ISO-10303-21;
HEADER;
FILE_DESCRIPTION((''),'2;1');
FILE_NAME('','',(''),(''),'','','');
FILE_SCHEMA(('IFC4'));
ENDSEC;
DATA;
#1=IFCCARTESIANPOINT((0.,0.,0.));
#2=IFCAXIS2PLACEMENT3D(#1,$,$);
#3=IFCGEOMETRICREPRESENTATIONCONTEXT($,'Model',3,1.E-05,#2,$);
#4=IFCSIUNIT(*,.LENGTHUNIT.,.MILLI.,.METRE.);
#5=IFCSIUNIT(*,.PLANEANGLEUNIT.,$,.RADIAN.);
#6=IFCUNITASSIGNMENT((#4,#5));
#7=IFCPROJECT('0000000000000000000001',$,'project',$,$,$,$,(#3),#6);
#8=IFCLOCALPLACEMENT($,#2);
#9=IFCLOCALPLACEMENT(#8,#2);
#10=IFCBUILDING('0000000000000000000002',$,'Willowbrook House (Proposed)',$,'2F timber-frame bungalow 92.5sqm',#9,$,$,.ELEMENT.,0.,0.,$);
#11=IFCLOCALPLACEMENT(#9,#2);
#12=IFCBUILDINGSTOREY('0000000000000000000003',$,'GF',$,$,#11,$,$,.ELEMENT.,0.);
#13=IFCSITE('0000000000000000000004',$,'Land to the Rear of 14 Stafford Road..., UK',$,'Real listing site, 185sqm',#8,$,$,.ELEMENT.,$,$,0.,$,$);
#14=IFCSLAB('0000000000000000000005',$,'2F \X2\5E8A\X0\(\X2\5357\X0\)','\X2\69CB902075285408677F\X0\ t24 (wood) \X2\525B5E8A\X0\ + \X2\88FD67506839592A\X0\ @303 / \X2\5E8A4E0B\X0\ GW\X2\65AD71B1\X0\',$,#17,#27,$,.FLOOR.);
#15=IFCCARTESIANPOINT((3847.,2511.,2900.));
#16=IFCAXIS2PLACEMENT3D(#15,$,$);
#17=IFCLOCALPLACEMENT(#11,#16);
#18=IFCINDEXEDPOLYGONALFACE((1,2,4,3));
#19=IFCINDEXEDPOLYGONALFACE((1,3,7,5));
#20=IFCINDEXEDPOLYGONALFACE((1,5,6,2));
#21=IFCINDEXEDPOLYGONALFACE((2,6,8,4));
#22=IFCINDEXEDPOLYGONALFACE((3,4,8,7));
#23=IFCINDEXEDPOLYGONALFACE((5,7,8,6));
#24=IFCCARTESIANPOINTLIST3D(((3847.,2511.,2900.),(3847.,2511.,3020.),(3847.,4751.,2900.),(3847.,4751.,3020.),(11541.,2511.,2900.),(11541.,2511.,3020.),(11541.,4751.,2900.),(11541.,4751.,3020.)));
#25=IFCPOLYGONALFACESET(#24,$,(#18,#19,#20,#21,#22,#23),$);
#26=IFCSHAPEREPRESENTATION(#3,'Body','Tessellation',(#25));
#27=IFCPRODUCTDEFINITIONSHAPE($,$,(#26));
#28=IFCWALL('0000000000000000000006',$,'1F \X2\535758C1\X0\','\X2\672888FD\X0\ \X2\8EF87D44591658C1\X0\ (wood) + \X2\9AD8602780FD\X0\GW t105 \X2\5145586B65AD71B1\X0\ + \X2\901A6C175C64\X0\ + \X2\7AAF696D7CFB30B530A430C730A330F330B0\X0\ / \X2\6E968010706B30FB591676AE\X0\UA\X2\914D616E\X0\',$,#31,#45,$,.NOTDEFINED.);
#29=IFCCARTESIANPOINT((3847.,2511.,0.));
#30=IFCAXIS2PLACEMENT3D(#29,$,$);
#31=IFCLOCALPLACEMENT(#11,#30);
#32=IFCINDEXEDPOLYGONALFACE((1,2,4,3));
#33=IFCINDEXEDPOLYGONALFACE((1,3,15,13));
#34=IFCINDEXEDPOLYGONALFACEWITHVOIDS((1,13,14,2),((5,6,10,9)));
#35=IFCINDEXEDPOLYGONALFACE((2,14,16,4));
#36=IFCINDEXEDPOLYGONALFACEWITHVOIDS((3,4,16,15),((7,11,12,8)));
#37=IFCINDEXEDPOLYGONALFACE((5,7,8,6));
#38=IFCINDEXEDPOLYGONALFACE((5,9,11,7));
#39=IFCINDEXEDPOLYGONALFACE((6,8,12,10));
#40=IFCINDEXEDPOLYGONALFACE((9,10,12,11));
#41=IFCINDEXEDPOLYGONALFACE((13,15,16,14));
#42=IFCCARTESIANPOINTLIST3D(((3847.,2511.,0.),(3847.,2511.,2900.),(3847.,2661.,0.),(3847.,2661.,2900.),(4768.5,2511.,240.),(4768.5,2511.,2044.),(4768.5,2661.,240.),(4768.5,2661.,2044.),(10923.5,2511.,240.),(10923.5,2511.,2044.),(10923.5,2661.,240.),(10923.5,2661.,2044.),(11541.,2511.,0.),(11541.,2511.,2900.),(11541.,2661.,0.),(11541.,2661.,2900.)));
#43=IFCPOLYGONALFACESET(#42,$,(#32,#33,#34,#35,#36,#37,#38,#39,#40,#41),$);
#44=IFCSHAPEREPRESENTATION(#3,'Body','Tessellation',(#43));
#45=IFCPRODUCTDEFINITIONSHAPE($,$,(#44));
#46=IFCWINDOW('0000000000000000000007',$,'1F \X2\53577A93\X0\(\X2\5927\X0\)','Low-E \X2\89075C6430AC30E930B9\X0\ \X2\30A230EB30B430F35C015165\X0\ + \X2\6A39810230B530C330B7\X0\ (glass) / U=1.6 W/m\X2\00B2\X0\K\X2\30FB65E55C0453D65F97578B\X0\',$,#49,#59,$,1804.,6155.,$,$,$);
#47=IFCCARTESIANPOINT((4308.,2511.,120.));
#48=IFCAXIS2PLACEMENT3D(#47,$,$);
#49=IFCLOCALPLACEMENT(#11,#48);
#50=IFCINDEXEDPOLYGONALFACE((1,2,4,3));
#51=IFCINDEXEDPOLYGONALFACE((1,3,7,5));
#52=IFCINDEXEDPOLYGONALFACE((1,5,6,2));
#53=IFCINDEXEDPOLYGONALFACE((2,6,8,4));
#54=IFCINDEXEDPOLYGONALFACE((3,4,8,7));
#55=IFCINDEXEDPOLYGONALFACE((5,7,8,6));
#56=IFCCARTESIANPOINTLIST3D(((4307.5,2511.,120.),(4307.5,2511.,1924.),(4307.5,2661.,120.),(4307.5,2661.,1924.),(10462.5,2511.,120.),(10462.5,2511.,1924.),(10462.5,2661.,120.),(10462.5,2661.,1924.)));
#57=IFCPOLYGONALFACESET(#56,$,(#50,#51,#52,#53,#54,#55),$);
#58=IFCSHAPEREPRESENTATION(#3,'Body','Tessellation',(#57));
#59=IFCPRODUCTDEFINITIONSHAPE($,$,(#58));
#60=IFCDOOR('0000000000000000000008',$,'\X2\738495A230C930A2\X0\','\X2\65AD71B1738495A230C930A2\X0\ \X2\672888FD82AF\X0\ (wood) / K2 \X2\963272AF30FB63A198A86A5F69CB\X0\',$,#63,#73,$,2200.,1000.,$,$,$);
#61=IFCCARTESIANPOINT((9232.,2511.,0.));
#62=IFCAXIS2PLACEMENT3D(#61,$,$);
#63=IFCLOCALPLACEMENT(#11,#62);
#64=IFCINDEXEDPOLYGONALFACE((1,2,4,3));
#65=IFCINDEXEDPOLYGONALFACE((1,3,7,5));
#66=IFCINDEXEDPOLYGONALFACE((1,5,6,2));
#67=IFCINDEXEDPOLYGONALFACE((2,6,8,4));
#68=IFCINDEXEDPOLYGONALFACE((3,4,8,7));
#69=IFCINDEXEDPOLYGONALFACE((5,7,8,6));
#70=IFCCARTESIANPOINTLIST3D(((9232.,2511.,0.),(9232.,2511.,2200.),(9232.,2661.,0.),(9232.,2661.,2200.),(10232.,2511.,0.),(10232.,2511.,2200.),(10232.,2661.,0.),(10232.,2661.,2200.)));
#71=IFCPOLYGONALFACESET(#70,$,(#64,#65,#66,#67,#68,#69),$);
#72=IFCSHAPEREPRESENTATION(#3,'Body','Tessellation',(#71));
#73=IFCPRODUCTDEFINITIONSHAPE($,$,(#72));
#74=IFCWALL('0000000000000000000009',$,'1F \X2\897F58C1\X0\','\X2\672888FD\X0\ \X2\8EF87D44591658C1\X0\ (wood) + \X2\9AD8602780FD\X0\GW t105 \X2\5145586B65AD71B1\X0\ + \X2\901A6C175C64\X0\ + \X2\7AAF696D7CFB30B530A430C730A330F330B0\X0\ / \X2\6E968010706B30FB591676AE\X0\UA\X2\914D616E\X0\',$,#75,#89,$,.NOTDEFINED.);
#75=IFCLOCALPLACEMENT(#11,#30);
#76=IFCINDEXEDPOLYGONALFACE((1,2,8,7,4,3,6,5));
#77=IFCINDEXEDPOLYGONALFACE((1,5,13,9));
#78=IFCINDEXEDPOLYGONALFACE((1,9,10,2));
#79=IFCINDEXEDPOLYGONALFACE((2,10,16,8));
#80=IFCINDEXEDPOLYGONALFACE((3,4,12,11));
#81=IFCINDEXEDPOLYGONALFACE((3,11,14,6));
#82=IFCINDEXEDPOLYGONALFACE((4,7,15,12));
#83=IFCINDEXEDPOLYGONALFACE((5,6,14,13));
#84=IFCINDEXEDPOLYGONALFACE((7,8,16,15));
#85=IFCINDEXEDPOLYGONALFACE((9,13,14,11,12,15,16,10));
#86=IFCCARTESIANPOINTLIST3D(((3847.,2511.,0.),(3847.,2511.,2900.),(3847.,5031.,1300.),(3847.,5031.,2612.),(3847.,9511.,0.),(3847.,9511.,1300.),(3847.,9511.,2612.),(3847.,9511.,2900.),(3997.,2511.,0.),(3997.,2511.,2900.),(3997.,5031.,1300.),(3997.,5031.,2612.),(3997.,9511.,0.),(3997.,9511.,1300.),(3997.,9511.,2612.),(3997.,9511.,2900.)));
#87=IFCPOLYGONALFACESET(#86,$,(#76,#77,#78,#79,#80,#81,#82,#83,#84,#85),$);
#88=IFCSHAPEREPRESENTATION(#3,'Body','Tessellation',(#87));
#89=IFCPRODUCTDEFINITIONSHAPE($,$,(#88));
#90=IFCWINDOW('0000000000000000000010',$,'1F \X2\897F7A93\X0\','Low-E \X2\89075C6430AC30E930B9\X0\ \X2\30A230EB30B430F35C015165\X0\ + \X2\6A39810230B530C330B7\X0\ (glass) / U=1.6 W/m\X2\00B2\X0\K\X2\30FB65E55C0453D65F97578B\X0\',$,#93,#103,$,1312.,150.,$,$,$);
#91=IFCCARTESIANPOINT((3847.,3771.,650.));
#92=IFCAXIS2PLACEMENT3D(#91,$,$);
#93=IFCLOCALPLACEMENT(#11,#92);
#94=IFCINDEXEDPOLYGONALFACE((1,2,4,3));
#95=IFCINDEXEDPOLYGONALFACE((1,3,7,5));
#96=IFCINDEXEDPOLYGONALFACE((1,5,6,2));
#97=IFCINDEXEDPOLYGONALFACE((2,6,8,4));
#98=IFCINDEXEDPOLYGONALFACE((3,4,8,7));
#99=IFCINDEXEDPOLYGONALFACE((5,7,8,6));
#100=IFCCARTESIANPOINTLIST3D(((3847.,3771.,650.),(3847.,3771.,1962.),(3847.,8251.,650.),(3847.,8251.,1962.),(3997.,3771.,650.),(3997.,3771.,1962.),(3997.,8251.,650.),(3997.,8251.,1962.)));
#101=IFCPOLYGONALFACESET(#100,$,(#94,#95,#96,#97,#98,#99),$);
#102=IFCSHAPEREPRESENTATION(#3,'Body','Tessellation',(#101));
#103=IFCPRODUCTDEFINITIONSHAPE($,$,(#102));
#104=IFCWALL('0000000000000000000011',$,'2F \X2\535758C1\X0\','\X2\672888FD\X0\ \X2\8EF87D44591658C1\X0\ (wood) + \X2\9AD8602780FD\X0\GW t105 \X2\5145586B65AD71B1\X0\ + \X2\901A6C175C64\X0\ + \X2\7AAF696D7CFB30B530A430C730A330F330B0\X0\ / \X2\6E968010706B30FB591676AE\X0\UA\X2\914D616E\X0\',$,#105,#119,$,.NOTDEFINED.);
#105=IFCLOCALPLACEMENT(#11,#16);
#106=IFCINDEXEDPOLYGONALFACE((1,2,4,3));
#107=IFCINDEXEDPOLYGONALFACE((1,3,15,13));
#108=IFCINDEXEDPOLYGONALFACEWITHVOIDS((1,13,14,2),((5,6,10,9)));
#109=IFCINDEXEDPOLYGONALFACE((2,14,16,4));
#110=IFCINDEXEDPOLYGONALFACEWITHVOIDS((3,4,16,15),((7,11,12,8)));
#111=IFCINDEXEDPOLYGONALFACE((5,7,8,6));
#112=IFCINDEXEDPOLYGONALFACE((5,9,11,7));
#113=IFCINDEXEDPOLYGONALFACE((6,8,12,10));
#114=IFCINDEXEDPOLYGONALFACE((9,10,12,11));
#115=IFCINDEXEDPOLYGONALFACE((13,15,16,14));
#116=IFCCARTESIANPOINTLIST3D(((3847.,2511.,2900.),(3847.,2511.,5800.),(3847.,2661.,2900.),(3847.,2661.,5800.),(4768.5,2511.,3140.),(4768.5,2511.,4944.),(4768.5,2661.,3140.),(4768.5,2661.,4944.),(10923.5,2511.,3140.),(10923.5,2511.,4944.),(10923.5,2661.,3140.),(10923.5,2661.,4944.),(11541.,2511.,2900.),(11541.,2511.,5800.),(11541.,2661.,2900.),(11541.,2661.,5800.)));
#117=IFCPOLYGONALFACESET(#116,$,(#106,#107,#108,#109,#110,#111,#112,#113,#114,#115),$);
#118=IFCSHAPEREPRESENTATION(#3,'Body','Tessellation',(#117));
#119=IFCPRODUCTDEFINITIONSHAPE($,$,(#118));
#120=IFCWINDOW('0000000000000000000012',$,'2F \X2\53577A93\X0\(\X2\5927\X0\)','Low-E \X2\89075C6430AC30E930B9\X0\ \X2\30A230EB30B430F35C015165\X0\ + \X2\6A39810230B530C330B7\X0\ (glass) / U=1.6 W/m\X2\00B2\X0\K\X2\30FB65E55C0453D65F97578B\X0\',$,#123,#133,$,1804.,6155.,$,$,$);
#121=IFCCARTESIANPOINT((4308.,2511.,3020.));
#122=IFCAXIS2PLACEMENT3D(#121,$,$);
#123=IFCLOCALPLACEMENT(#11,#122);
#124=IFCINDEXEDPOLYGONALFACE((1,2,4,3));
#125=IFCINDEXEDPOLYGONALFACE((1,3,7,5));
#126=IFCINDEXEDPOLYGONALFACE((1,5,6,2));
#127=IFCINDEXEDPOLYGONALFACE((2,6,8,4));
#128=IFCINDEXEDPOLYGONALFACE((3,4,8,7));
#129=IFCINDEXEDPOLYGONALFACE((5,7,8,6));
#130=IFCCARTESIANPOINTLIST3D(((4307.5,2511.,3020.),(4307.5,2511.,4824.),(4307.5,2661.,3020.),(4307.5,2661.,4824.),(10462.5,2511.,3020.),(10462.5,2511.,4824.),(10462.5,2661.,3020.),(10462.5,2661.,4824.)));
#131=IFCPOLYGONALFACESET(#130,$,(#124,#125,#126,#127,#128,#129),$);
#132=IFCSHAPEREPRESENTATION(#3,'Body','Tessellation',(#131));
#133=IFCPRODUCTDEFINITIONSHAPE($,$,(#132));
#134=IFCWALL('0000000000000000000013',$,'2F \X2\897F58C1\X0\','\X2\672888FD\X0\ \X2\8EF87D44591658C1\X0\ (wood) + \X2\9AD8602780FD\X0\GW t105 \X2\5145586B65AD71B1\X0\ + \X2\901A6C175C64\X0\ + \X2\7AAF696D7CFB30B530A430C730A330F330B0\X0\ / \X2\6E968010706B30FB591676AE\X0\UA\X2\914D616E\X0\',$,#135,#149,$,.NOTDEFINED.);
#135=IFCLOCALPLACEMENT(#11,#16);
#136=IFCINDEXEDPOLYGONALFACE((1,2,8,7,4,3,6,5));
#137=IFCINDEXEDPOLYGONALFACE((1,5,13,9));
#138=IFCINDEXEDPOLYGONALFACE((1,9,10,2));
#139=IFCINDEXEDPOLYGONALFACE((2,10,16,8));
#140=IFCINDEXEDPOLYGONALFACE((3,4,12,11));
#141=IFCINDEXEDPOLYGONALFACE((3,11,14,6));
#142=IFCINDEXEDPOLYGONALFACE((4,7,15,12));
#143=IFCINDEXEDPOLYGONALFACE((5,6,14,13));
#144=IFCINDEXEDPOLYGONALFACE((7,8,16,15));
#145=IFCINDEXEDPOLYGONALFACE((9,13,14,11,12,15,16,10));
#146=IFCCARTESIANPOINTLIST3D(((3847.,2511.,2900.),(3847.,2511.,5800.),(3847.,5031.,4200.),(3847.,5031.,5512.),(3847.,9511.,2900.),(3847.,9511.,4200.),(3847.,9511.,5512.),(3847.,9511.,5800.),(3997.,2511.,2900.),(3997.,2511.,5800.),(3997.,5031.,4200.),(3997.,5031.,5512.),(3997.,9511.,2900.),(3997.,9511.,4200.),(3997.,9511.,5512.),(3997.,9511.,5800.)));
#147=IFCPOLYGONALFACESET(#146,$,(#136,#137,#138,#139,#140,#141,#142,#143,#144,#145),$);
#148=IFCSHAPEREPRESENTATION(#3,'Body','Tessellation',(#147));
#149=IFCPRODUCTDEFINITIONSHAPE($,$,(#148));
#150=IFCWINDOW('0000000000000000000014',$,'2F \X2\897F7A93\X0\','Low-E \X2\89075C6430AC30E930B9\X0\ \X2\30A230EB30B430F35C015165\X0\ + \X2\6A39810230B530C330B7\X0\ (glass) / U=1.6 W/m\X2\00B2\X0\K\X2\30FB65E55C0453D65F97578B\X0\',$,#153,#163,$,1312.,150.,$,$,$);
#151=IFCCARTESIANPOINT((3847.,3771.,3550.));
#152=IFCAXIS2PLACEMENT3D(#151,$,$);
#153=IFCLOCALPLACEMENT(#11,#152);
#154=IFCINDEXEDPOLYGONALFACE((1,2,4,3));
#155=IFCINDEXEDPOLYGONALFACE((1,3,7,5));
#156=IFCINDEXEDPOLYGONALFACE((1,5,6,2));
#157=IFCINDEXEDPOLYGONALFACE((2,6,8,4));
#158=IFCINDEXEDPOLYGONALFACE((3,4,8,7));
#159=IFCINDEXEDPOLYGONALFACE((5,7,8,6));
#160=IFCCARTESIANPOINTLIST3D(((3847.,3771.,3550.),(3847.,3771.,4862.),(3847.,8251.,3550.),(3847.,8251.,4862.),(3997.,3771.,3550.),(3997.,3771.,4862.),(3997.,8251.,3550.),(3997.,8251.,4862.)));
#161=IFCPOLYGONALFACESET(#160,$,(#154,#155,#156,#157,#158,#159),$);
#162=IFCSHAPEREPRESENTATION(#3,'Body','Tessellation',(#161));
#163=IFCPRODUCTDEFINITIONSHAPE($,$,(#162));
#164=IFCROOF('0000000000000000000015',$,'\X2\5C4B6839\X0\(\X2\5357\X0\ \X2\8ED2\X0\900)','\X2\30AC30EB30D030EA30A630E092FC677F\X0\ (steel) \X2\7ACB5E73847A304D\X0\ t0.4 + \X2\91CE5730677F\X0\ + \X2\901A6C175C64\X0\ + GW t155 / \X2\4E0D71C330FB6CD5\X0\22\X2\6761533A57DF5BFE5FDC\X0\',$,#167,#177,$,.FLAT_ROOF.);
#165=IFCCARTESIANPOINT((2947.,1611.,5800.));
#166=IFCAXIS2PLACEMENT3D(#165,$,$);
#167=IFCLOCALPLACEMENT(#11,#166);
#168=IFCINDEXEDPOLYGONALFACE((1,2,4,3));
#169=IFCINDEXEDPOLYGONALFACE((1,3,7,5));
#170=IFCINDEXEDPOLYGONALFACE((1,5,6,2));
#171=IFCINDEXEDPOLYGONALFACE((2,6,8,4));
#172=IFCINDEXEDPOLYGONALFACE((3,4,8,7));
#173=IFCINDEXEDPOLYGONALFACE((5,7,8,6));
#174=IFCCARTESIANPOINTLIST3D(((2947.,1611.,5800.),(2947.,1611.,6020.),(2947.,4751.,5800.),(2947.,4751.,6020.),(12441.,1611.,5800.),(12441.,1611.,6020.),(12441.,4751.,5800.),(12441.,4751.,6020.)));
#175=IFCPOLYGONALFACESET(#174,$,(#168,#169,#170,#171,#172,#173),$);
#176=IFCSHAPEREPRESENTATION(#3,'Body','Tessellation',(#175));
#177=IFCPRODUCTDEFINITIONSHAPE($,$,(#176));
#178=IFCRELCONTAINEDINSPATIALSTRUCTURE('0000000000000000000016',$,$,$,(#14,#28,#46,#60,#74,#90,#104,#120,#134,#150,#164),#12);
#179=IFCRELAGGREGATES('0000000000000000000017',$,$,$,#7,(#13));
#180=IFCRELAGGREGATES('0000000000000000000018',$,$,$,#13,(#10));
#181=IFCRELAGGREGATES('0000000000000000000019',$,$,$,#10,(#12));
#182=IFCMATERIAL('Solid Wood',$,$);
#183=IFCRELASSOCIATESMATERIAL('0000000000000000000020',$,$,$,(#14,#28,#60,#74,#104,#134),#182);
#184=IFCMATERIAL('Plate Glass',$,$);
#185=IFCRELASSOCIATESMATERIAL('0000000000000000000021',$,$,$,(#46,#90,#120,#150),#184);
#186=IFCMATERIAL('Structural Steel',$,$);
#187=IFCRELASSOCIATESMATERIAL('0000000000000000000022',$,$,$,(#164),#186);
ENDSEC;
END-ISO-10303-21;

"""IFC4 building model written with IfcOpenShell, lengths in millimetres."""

from ifc_helpers import new_model, si_unit, frame, frame_2d, origin, place, context, project, spatial, rectangle, extrude, material, element, fill, save


model = new_model("IFC4")

# Units and contexts
model_context = context("Model", 3, precision=1e-05, world=origin())
ifc_project = project(units=[si_unit("LENGTHUNIT", "METRE", prefix="MILLI"), si_unit("PLANEANGLEUNIT", "RADIAN")], contexts=[model_context])

# Site, building, storey
site_placement = place(None, origin())
site = spatial("IfcSite", under=ifc_project, at=site_placement, Name="Land to the Rear of 14 Stafford Road..., UK", ObjectType="Real listing site, 185sqm", CompositionType="ELEMENT", RefElevation=0.0)
building_placement = place(site_placement, origin())
building = spatial("IfcBuilding", under=site, at=building_placement, Name="Willowbrook House (Proposed)", ObjectType="2F timber-frame bungalow 92.5sqm", CompositionType="ELEMENT", ElevationOfRefHeight=0.0, ElevationOfTerrain=0.0)
storey_placement = place(building_placement, origin())
storey = spatial("IfcBuildingStorey", under=building, at=storey_placement, Name="GF", CompositionType="ELEMENT", Elevation=0.0)

# Slab
ifc_material_1 = material(Name="Solid Wood")
slab_1_placement = place(storey_placement, frame((3847.0, 2511.0, 2900.0)))
element("IfcSlab", 1, at=slab_1_placement, inside=storey, material=ifc_material_1, Name="2F 床(南)", Description="構造用合板 t24 (wood) 剛床 + 製材根太 @303 / 床下 GW断熱", PredefinedType="FLOOR", context=model_context, shape_type="SweptSolid", body=[
    extrude(rectangle(XDim=7694.0, YDim=2240.0, at=frame_2d((3847.0, 1120.0))), frame((3847.0, 2511.0, 2900.0)), (0.0, 0.0, 1.0), 120.0),
])

# Wall, openings, window, door
wall_1_placement = place(storey_placement, frame((3847.0, 2511.0, 0.0)))
wall_1 = element("IfcWall", 2, at=wall_1_placement, inside=storey, material=ifc_material_1, Name="1F 南壁", Description="木製 軸組外壁 (wood) + 高性能GW t105 充填断熱 + 通気層 + 窯業系サイディング / 準耐火・外皮UA配慮", PredefinedType="NOTDEFINED", context=model_context, shape_type="SweptSolid", body=[
    extrude(rectangle(XDim=7694.0, YDim=150.0, at=frame_2d((3847.0, 75.0))), frame((3847.0, 2511.0, 0.0)), (0.0, 0.0, 1.0), 2900.0),
])
opening_1_placement = place(storey_placement, frame((4308.0, 2511.0, 120.0)))
opening_1 = element("IfcOpeningElement", 3, at=opening_1_placement, cuts=wall_1, PredefinedType="NOTDEFINED", context=model_context, shape_type="SweptSolid", body=[
    extrude(rectangle(XDim=6155.0, YDim=150.0, at=frame_2d((3077.0, 75.0))), frame((4308.0, 2511.0, 120.0)), (0.0, 0.0, 1.0), 1804.0),
])
opening_2_placement = place(storey_placement, frame((9232.0, 2511.0, 0.0)))
opening_2 = element("IfcOpeningElement", 4, at=opening_2_placement, cuts=wall_1, PredefinedType="NOTDEFINED", context=model_context, shape_type="SweptSolid", body=[
    extrude(rectangle(XDim=1000.0, YDim=150.0, at=frame_2d((500.0, 75.0))), frame((9232.0, 2511.0, 0.0)), (0.0, 0.0, 1.0), 2200.0),
])
ifc_material_2 = material(Name="Plate Glass")
window_1_placement = place(storey_placement, frame((4308.0, 2511.0, 120.0)))
window_1 = element("IfcWindow", 5, at=window_1_placement, inside=storey, material=ifc_material_2, Name="1F 南窓(大)", Description="Low-E 複層ガラス アルゴン封入 + 樹脂サッシ (glass) / U=1.6 W/m²K・日射取得型", OverallHeight=1804.0, OverallWidth=6155.0, context=model_context, shape_type="SweptSolid", body=[
    extrude(rectangle(XDim=6155.0, YDim=150.0, at=frame_2d((3077.0, 75.0))), frame((4308.0, 2511.0, 120.0)), (0.0, 0.0, 1.0), 1804.0),
])
fill(opening_1, window_1)
door_placement = place(storey_placement, frame((9232.0, 2511.0, 0.0)))
door = element("IfcDoor", 6, at=door_placement, inside=storey, material=ifc_material_1, Name="玄関ドア", Description="断熱玄関ドア 木製芯 (wood) / K2 防犯・採風機構", OverallHeight=2200.0, OverallWidth=1000.0, context=model_context, shape_type="SweptSolid", body=[
    extrude(rectangle(XDim=1000.0, YDim=150.0, at=frame_2d((500.0, 75.0))), frame((9232.0, 2511.0, 0.0)), (0.0, 0.0, 1.0), 2200.0),
])
fill(opening_2, door)

# Walls, openings, windows
wall_2_placement = place(storey_placement, frame((3847.0, 2511.0, 0.0)))
wall_2 = element("IfcWall", 7, at=wall_2_placement, inside=storey, material=ifc_material_1, Name="1F 西壁", Description="木製 軸組外壁 (wood) + 高性能GW t105 充填断熱 + 通気層 + 窯業系サイディング / 準耐火・外皮UA配慮", PredefinedType="NOTDEFINED", context=model_context, shape_type="SweptSolid", body=[
    extrude(rectangle(XDim=150.0, YDim=7000.0, at=frame_2d((75.0, 3500.0))), frame((3847.0, 2511.0, 0.0)), (0.0, 0.0, 1.0), 2900.0),
])
opening_3_placement = place(storey_placement, frame((3847.0, 3771.0, 650.0)))
opening_3 = element("IfcOpeningElement", 8, at=opening_3_placement, cuts=wall_2, PredefinedType="NOTDEFINED", context=model_context, shape_type="SweptSolid", body=[
    extrude(rectangle(XDim=150.0, YDim=4480.0, at=frame_2d((75.0, 2240.0))), frame((3847.0, 3771.0, 650.0)), (0.0, 0.0, 1.0), 1312.0),
])
window_2_placement = place(storey_placement, frame((3847.0, 3771.0, 650.0)))
window_2 = element("IfcWindow", 9, at=window_2_placement, inside=storey, material=ifc_material_2, Name="1F 西窓", Description="Low-E 複層ガラス アルゴン封入 + 樹脂サッシ (glass) / U=1.6 W/m²K・日射取得型", OverallHeight=1312.0, OverallWidth=150.0, context=model_context, shape_type="SweptSolid", body=[
    extrude(rectangle(XDim=150.0, YDim=4480.0, at=frame_2d((75.0, 2240.0))), frame((3847.0, 3771.0, 650.0)), (0.0, 0.0, 1.0), 1312.0),
])
fill(opening_3, window_2)
wall_3_placement = place(storey_placement, frame((3847.0, 2511.0, 2900.0)))
wall_3 = element("IfcWall", 10, at=wall_3_placement, inside=storey, material=ifc_material_1, Name="2F 南壁", Description="木製 軸組外壁 (wood) + 高性能GW t105 充填断熱 + 通気層 + 窯業系サイディング / 準耐火・外皮UA配慮", PredefinedType="NOTDEFINED", context=model_context, shape_type="SweptSolid", body=[
    extrude(rectangle(XDim=7694.0, YDim=150.0, at=frame_2d((3847.0, 75.0))), frame((3847.0, 2511.0, 2900.0)), (0.0, 0.0, 1.0), 2900.0),
])
opening_4_placement = place(storey_placement, frame((4308.0, 2511.0, 3020.0)))
opening_4 = element("IfcOpeningElement", 11, at=opening_4_placement, cuts=wall_3, PredefinedType="NOTDEFINED", context=model_context, shape_type="SweptSolid", body=[
    extrude(rectangle(XDim=6155.0, YDim=150.0, at=frame_2d((3077.0, 75.0))), frame((4308.0, 2511.0, 3020.0)), (0.0, 0.0, 1.0), 1804.0),
])
window_3_placement = place(storey_placement, frame((4308.0, 2511.0, 3020.0)))
window_3 = element("IfcWindow", 12, at=window_3_placement, inside=storey, material=ifc_material_2, Name="2F 南窓(大)", Description="Low-E 複層ガラス アルゴン封入 + 樹脂サッシ (glass) / U=1.6 W/m²K・日射取得型", OverallHeight=1804.0, OverallWidth=6155.0, context=model_context, shape_type="SweptSolid", body=[
    extrude(rectangle(XDim=6155.0, YDim=150.0, at=frame_2d((3077.0, 75.0))), frame((4308.0, 2511.0, 3020.0)), (0.0, 0.0, 1.0), 1804.0),
])
fill(opening_4, window_3)
wall_4_placement = place(storey_placement, frame((3847.0, 2511.0, 2900.0)))
wall_4 = element("IfcWall", 13, at=wall_4_placement, inside=storey, material=ifc_material_1, Name="2F 西壁", Description="木製 軸組外壁 (wood) + 高性能GW t105 充填断熱 + 通気層 + 窯業系サイディング / 準耐火・外皮UA配慮", PredefinedType="NOTDEFINED", context=model_context, shape_type="SweptSolid", body=[
    extrude(rectangle(XDim=150.0, YDim=7000.0, at=frame_2d((75.0, 3500.0))), frame((3847.0, 2511.0, 2900.0)), (0.0, 0.0, 1.0), 2900.0),
])
opening_5_placement = place(storey_placement, frame((3847.0, 3771.0, 3550.0)))
opening_5 = element("IfcOpeningElement", 14, at=opening_5_placement, cuts=wall_4, PredefinedType="NOTDEFINED", context=model_context, shape_type="SweptSolid", body=[
    extrude(rectangle(XDim=150.0, YDim=4480.0, at=frame_2d((75.0, 2240.0))), frame((3847.0, 3771.0, 3550.0)), (0.0, 0.0, 1.0), 1312.0),
])
window_4_placement = place(storey_placement, frame((3847.0, 3771.0, 3550.0)))
window_4 = element("IfcWindow", 15, at=window_4_placement, inside=storey, material=ifc_material_2, Name="2F 西窓", Description="Low-E 複層ガラス アルゴン封入 + 樹脂サッシ (glass) / U=1.6 W/m²K・日射取得型", OverallHeight=1312.0, OverallWidth=150.0, context=model_context, shape_type="SweptSolid", body=[
    extrude(rectangle(XDim=150.0, YDim=4480.0, at=frame_2d((75.0, 2240.0))), frame((3847.0, 3771.0, 3550.0)), (0.0, 0.0, 1.0), 1312.0),
])
fill(opening_5, window_4)

# Roof
ifc_material_3 = material(Name="Structural Steel")
roof_1_placement = place(storey_placement, frame((2947.0, 1611.0, 5800.0)))
element("IfcRoof", 16, at=roof_1_placement, inside=storey, material=ifc_material_3, Name="屋根(南 軒900)", Description="ガルバリウム鋼板 (steel) 立平葺き t0.4 + 野地板 + 通気層 + GW t155 / 不燃・法22条区域対応", PredefinedType="FLAT_ROOF", context=model_context, shape_type="SweptSolid", body=[
    extrude(rectangle(XDim=9494.0, YDim=3140.0, at=frame_2d((4747.0, 1570.0))), frame((2947.0, 1611.0, 5800.0)), (0.0, 0.0, 1.0), 220.0),
])

save(model, "model.ifc")
